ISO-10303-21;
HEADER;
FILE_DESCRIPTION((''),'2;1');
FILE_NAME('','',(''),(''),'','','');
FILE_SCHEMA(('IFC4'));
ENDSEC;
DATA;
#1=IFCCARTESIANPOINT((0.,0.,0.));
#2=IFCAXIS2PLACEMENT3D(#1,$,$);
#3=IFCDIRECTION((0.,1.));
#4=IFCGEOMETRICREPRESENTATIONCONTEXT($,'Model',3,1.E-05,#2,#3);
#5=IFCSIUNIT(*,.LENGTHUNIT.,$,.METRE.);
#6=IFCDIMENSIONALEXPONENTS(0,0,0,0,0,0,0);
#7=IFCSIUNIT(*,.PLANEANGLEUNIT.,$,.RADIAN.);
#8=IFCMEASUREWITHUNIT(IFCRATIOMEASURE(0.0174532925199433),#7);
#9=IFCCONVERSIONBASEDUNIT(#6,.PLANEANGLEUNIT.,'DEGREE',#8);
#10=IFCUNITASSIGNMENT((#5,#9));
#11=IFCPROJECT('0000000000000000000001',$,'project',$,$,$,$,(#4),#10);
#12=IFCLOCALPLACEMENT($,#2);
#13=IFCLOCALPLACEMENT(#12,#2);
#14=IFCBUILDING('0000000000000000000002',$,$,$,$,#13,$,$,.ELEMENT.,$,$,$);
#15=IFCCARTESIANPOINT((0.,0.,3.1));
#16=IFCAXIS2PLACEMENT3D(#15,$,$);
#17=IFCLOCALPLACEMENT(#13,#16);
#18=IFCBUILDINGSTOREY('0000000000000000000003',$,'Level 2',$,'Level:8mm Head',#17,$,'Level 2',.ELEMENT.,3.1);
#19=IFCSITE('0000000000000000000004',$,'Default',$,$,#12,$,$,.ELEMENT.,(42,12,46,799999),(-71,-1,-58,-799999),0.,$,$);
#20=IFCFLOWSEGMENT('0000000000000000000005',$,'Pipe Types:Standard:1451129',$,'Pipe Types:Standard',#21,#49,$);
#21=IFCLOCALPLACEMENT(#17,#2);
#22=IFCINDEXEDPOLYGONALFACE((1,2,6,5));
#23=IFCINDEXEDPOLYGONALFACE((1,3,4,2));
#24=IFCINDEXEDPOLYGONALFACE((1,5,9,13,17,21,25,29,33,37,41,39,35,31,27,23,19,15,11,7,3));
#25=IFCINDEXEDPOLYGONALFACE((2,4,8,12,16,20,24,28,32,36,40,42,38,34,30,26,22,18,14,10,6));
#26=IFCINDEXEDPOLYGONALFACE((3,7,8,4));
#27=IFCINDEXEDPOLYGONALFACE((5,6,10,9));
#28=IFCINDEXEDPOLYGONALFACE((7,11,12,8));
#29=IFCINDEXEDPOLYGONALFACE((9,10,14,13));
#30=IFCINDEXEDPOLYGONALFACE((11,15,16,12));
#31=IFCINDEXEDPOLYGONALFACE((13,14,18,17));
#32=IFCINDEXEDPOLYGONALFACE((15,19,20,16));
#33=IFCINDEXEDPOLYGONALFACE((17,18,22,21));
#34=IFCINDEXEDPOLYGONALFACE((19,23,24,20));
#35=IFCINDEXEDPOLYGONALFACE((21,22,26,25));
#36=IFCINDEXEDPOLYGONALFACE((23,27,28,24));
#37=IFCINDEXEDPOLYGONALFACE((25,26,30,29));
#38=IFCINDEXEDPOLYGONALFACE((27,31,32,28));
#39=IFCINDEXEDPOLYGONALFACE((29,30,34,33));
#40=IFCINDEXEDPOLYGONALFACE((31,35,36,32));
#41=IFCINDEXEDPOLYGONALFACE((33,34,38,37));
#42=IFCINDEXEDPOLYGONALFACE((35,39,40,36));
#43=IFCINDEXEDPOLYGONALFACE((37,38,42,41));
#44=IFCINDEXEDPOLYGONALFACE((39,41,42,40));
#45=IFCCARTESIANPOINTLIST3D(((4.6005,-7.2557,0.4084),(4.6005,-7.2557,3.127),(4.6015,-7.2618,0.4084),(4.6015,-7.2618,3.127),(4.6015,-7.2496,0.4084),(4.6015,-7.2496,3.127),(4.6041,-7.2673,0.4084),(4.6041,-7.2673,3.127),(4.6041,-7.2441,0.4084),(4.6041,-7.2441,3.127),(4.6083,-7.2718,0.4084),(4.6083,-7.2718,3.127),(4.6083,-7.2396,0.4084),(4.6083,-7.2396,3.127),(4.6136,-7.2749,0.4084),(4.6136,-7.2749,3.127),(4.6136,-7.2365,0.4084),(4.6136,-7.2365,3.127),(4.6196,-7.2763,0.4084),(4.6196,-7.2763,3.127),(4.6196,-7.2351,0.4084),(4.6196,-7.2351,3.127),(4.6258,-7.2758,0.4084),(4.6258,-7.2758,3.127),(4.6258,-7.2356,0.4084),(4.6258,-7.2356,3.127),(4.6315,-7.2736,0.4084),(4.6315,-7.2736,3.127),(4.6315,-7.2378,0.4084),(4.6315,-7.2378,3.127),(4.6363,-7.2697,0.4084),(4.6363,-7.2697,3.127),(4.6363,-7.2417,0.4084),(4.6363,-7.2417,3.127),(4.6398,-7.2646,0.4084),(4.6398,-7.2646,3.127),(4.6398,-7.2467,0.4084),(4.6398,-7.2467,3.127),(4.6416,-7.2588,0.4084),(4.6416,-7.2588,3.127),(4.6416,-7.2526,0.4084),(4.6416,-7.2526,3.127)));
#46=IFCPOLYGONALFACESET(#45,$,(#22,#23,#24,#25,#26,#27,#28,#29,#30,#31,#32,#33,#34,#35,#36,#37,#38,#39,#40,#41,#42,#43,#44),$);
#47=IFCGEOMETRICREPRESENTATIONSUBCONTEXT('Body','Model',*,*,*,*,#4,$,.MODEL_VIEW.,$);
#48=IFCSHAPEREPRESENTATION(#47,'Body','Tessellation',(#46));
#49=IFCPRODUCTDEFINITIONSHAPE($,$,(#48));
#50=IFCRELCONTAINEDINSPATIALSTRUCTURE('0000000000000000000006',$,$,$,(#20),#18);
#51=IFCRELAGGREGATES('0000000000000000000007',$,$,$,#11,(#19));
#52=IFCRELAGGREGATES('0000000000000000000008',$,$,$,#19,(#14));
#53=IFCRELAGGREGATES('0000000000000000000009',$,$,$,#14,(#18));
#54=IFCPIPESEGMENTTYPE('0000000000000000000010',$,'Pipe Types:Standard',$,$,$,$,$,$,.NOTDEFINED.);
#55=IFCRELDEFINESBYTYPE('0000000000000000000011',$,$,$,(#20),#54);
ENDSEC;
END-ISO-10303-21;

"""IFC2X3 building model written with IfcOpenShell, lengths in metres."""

from ifc_helpers import new_model, entity, si_unit, converted_unit, direction, frame, frame_2d, origin, place, context, subcontext, project, spatial, circle, extrude, type_object, element, save


model = new_model("IFC2X3")

# Units and contexts
model_context = context("Model", 3, precision=1e-05, world=origin(), true_north=direction((0.0, 1.0)))
body_context = subcontext(model_context, "Body", "Model", "MODEL_VIEW")
ifc_project = project(units=[si_unit("LENGTHUNIT", "METRE"), converted_unit("PLANEANGLEUNIT", "DEGREE", entity("IfcRatioMeasure", 0.0174532925199433), si_unit("PLANEANGLEUNIT", "RADIAN"), dimensions=[0, 0, 0, 0, 0, 0, 0])], contexts=[model_context])

# Site, building, storey
site_placement = place(None, origin())
site = spatial("IfcSite", under=ifc_project, at=site_placement, Name="Default", CompositionType="ELEMENT", RefLatitude=(42, 12, 46, 799999), RefLongitude=(-71, -1, -58, -799999), RefElevation=0.0)
building_placement = place(site_placement, origin())
building = spatial("IfcBuilding", under=site, at=building_placement, CompositionType="ELEMENT")
storey_placement = place(building_placement, frame((0.0, 0.0, 3.1)))
storey = spatial("IfcBuildingStorey", under=building, at=storey_placement, Name="Level 2", ObjectType="Level:8mm Head", LongName="Level 2", CompositionType="ELEMENT", Elevation=3.1)

# Flow segment
pipe_segment_type = type_object("IfcPipeSegmentType", Name="Pipe Types:Standard", PredefinedType="NOTDEFINED")
flow_segment_1_placement = place(storey_placement, origin())
element("IfcFlowSegment", 1, at=flow_segment_1_placement, inside=storey, type_object=pipe_segment_type, Name="Pipe Types:Standard:1451129", ObjectType="Pipe Types:Standard", context=body_context, shape_type="SweptSolid", body=[
    extrude(circle(Radius=0.0206, at=frame_2d((0.0, 0.0), x_axis=(1.0, 0.0))), frame((4.6212, -7.2557, 0.4084), z_axis=(0.0, 0.0, 1.0), x_axis=(-1.0, 0.0, 0.0)), (0.0, 0.0, 1.0), 2.7186),
])

save(model, "model.ifc")
